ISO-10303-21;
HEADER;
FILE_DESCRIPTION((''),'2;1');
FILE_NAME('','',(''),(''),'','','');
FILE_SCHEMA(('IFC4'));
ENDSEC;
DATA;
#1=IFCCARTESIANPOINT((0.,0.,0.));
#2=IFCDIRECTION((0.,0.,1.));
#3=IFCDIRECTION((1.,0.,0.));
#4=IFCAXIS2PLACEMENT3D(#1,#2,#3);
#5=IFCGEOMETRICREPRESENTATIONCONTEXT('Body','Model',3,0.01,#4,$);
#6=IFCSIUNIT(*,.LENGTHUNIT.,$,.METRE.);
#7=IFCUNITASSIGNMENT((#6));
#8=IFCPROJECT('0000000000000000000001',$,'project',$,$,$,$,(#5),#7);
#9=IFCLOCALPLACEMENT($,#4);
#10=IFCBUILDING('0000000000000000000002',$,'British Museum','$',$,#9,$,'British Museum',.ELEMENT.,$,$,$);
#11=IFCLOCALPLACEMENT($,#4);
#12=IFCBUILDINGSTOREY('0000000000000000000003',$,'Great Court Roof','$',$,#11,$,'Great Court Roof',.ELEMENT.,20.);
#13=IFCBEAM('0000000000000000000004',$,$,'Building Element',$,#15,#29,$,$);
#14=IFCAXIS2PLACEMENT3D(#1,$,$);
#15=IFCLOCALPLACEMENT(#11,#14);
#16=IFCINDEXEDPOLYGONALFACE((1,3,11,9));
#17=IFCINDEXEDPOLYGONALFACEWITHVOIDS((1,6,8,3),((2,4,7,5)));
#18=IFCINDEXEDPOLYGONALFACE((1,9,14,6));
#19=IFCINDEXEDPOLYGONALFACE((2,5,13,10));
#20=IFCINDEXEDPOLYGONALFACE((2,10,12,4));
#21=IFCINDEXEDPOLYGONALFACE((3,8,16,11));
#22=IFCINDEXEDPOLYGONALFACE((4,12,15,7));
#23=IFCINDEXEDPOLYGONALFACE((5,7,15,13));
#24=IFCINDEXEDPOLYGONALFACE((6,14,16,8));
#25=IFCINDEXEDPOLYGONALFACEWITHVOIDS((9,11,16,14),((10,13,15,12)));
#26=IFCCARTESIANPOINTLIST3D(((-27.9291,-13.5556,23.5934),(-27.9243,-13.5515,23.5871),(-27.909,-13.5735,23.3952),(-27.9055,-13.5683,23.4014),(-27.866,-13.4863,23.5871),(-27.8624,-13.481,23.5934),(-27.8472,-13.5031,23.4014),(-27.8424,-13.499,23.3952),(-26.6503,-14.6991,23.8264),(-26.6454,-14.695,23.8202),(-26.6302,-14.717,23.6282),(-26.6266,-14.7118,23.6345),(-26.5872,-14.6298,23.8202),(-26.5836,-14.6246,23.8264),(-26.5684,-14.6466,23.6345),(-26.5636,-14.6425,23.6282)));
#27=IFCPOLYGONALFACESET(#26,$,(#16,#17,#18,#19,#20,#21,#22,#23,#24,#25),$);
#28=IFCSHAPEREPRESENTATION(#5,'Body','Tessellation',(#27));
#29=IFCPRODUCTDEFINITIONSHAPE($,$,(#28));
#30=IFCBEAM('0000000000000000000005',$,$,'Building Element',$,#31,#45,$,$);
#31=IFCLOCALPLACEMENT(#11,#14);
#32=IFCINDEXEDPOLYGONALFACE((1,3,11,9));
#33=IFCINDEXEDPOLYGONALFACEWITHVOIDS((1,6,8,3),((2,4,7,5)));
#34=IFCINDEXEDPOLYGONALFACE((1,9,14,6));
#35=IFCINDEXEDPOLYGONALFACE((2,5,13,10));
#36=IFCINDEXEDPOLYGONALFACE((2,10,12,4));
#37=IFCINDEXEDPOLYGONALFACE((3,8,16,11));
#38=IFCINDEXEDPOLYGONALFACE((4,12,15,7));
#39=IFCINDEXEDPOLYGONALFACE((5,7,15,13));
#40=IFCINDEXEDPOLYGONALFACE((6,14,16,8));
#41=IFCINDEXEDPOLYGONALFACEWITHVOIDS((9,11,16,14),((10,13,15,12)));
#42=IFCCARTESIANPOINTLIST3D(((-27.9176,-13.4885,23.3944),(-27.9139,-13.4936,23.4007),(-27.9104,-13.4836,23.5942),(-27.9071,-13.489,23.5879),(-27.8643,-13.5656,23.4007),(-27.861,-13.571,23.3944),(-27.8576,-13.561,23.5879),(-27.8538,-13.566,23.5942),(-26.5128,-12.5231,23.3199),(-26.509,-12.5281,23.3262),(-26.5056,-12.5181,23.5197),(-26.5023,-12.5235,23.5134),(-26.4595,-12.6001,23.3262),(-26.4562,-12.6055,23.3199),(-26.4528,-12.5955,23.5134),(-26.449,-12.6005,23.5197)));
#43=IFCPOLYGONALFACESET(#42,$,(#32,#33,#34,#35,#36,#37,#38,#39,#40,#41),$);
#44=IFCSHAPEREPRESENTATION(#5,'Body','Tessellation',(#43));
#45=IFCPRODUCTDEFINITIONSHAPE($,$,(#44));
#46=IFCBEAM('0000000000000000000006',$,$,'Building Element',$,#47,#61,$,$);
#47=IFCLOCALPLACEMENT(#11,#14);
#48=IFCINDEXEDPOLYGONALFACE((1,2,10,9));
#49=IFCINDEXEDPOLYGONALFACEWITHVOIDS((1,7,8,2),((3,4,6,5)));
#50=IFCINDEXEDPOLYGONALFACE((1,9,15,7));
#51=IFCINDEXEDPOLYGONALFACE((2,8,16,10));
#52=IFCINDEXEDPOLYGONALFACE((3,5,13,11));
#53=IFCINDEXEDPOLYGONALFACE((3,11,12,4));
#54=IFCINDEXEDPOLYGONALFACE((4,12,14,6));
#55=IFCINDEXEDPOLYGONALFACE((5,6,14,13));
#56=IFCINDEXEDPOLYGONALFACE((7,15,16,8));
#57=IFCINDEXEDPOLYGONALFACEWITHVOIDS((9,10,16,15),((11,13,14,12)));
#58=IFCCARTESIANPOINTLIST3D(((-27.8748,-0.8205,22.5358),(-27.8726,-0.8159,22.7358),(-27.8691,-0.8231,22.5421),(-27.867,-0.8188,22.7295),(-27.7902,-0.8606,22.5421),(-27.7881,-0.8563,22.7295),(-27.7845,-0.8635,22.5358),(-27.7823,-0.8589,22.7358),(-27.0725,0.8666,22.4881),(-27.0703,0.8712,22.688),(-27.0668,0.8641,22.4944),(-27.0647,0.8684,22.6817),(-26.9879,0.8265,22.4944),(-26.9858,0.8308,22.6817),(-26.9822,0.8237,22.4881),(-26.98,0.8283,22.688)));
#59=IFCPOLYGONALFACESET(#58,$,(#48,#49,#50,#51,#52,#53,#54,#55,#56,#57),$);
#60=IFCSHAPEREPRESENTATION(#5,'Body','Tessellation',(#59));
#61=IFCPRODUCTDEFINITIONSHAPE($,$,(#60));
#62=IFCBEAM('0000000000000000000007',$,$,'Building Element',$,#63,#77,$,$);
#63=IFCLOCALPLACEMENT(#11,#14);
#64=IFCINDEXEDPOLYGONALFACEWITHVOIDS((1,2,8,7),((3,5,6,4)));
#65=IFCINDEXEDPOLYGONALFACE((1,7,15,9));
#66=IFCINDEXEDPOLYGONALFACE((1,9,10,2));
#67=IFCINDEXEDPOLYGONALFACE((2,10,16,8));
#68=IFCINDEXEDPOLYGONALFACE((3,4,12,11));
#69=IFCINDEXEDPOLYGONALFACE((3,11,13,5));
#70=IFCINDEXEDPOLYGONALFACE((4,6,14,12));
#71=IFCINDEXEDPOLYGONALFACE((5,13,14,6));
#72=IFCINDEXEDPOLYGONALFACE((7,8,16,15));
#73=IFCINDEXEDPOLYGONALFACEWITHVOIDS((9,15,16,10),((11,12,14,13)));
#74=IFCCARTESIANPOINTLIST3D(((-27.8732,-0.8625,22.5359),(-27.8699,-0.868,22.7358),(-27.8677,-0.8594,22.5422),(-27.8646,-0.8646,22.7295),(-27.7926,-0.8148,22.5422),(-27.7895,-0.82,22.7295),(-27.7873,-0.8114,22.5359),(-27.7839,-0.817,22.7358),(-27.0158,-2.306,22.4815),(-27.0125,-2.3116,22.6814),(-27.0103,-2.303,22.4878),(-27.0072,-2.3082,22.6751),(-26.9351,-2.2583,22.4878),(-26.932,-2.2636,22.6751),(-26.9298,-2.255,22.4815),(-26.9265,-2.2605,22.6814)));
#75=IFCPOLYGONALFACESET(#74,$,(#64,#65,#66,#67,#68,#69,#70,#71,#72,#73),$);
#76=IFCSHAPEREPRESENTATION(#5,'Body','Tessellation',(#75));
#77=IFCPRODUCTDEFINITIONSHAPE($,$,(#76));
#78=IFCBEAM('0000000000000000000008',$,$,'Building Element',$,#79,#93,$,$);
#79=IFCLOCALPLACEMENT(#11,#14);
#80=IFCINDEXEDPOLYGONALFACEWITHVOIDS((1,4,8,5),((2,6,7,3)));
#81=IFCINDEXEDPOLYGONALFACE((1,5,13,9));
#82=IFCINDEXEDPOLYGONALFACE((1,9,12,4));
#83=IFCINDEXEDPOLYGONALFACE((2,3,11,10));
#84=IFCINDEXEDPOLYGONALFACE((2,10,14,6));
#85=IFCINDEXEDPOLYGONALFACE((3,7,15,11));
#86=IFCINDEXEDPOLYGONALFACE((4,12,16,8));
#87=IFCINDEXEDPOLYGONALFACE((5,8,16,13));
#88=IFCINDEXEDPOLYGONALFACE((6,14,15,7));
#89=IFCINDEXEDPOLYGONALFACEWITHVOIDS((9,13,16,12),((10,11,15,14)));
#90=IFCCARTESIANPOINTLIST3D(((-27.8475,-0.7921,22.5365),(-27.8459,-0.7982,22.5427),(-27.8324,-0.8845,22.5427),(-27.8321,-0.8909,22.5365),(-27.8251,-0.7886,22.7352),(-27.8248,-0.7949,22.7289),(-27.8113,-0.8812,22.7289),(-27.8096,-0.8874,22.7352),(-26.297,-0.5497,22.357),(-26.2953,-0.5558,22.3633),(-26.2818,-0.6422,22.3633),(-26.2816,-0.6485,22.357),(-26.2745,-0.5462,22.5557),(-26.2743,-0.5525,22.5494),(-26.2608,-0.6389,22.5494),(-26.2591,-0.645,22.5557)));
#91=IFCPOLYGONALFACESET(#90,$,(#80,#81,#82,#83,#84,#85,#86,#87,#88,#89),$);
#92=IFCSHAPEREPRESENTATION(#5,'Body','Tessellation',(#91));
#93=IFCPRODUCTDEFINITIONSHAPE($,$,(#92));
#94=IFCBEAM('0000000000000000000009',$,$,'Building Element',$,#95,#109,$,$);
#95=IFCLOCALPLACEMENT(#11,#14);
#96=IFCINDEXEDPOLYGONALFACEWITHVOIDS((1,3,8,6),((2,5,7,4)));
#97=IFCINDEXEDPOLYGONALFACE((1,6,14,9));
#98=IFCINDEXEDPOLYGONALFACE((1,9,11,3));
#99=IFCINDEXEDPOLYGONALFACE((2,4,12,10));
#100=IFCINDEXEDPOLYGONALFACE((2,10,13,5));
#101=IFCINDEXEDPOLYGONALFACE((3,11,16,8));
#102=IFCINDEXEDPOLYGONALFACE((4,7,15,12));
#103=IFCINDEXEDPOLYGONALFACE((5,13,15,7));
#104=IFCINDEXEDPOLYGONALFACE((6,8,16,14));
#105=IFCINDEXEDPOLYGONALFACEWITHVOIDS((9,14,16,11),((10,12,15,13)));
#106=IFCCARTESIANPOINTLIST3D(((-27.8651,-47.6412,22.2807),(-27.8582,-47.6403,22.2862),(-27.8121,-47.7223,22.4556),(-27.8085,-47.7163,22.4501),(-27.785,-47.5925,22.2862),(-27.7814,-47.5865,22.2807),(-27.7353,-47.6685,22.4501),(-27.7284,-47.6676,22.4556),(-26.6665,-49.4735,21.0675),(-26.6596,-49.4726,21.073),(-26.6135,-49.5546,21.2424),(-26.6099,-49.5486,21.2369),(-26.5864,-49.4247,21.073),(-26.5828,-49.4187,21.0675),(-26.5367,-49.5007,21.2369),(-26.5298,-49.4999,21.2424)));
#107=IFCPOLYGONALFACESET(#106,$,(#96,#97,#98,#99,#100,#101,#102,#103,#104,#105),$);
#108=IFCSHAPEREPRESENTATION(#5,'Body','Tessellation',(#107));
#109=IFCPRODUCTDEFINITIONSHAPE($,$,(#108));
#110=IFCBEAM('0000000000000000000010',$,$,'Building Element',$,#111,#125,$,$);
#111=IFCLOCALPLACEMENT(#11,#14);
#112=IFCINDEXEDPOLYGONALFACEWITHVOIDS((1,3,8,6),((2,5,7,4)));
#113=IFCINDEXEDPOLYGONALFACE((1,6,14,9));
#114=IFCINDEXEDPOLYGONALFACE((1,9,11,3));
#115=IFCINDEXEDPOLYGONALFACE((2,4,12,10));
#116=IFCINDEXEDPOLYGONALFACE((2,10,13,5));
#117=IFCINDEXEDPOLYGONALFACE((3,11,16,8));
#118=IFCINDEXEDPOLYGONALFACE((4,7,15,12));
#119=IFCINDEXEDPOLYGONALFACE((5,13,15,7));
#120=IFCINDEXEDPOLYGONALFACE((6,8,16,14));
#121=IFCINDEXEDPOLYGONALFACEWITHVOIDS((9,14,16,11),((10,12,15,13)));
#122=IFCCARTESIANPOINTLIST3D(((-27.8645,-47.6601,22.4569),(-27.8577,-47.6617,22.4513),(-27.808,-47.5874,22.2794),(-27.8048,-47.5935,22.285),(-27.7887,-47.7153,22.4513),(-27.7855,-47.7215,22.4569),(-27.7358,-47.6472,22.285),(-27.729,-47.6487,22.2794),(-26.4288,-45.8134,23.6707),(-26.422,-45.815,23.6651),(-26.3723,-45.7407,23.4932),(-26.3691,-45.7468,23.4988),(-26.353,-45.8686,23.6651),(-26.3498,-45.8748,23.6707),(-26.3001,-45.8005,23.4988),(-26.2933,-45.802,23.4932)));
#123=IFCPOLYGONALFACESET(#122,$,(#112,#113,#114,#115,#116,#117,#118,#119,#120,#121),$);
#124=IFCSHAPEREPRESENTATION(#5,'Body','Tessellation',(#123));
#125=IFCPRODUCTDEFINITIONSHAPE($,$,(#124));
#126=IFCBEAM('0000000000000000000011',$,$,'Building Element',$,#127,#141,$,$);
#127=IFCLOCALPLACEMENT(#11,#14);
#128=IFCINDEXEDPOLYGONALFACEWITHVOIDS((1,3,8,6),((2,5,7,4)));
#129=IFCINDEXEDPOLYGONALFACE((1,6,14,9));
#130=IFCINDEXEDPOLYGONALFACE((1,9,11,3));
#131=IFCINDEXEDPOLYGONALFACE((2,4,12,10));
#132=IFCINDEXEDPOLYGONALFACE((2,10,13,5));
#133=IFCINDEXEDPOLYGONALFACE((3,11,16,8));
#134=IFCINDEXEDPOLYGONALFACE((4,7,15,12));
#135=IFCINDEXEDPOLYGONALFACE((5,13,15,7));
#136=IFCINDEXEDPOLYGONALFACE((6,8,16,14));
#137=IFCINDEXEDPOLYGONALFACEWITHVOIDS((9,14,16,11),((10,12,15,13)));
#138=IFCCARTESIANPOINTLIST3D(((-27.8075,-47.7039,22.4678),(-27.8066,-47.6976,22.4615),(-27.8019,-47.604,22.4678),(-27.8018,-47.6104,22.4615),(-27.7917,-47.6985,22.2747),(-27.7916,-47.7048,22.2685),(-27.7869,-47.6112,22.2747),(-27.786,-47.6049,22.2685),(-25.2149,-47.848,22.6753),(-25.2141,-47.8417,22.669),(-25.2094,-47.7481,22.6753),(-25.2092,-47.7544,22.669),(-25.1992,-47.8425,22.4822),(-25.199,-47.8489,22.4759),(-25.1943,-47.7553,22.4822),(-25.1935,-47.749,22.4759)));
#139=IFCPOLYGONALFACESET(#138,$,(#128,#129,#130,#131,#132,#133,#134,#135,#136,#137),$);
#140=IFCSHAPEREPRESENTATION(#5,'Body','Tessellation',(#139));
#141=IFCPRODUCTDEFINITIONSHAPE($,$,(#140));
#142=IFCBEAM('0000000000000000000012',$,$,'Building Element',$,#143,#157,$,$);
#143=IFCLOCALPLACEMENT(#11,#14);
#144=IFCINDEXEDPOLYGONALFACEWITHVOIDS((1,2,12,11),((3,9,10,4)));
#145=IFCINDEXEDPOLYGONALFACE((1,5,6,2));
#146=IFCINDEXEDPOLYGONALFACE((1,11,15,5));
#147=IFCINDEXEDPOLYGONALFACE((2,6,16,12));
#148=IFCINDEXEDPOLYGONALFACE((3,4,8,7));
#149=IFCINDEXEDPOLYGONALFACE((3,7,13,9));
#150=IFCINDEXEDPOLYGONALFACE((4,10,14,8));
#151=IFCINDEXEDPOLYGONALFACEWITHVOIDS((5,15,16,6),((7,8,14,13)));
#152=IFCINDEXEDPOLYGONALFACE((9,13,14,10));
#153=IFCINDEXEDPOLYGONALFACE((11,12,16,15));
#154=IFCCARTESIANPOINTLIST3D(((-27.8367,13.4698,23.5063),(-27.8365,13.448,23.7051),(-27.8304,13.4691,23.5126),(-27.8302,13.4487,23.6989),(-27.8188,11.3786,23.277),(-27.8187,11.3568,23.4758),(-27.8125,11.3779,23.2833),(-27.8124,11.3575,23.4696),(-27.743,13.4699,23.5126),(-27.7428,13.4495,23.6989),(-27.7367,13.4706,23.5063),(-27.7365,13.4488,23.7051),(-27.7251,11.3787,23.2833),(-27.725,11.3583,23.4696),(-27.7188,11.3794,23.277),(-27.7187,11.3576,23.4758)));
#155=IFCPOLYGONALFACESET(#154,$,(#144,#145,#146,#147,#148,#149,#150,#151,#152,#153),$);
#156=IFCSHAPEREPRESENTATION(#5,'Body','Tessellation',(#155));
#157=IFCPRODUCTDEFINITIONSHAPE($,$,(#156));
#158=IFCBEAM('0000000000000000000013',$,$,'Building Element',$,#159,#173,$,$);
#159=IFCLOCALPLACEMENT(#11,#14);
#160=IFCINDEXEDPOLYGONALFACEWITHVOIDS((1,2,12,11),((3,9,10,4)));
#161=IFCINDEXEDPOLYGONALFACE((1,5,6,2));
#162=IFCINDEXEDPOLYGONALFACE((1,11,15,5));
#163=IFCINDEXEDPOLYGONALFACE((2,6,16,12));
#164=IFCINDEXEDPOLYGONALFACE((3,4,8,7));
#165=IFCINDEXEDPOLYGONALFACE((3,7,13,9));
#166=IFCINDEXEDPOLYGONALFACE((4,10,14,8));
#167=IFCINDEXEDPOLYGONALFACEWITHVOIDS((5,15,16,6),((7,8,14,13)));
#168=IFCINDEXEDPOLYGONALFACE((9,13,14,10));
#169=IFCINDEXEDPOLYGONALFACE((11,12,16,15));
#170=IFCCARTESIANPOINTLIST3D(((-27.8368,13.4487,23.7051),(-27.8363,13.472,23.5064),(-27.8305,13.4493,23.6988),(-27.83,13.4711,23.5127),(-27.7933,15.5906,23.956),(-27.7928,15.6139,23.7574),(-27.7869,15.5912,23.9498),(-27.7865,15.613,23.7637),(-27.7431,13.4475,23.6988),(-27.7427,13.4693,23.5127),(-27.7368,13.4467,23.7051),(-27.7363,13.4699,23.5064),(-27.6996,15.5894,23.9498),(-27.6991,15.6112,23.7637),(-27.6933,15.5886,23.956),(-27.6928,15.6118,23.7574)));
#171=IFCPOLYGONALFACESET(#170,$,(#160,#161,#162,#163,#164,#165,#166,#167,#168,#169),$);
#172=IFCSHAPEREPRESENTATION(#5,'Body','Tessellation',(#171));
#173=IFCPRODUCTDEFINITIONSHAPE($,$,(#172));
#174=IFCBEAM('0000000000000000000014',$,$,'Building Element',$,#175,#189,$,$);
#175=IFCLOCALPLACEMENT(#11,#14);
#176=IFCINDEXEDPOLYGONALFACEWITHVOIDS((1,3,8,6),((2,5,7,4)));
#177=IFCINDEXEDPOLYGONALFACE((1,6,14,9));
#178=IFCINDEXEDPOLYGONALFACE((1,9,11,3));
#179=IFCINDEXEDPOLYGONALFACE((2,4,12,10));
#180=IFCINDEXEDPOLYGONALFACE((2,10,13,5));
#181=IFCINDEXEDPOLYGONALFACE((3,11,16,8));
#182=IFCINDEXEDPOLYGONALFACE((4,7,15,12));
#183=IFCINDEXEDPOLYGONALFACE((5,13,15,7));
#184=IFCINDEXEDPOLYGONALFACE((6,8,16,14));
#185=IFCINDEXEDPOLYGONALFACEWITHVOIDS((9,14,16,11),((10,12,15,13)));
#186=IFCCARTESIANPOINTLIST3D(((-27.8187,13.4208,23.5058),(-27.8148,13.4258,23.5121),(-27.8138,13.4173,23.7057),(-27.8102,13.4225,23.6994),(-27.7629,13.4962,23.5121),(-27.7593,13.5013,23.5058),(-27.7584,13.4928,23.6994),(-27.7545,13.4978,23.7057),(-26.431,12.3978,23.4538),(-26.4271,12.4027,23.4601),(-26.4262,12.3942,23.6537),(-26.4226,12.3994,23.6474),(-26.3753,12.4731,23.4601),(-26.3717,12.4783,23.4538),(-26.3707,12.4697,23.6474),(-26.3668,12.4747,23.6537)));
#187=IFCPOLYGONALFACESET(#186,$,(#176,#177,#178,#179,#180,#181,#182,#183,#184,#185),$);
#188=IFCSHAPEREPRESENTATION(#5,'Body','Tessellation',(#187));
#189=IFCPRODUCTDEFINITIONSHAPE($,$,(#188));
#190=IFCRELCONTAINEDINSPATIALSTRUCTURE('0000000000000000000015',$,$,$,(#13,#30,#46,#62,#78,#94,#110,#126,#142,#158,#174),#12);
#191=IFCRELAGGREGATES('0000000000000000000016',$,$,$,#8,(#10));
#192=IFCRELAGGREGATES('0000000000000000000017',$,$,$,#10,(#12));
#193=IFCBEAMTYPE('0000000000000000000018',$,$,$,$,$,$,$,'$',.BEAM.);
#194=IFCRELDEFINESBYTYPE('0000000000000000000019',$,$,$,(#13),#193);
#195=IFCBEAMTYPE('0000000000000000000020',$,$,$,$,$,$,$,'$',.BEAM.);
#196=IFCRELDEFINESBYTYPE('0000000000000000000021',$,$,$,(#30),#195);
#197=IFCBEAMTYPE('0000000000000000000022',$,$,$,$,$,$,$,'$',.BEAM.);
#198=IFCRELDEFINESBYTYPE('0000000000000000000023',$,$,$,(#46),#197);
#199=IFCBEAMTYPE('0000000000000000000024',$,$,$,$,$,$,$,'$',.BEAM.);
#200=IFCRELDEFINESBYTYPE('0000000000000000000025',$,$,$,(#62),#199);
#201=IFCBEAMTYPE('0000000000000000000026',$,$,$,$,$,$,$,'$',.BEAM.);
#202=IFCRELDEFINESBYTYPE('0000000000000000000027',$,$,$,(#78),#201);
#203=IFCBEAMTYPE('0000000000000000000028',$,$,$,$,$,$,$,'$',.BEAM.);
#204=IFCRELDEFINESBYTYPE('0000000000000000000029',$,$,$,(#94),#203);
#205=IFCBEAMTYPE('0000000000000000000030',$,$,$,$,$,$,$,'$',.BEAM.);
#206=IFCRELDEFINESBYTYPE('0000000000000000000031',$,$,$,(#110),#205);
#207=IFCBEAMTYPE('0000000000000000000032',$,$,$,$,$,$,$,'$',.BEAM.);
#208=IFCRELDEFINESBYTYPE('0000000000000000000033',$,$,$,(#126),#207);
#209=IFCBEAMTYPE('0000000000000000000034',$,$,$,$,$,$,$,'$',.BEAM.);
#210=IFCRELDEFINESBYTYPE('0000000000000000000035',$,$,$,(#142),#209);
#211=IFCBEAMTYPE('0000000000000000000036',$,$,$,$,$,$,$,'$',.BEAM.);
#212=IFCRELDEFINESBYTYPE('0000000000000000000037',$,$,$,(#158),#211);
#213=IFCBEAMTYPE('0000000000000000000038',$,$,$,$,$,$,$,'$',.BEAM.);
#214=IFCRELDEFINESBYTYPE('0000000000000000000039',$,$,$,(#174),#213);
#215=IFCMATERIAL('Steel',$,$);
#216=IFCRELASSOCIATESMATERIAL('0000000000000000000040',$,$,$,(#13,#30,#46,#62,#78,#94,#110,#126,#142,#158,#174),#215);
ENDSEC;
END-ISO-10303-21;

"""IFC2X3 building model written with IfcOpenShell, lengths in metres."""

from ifc_helpers import new_model, si_unit, frame, origin_with_axes, origin_2d, place, context, project, spatial, hollow_rectangle, extrude, material, type_object, element, save


model = new_model("IFC2X3")

# Units and contexts
model_context = context("Model", 3, precision=0.01, world=origin_with_axes(), identifier="Body")
ifc_project = project(units=[si_unit("LENGTHUNIT", "METRE")], contexts=[model_context])

# Building, storey
building_placement = place(None, origin_with_axes())
building = spatial("IfcBuilding", under=ifc_project, at=building_placement, Name="British Museum", Description="$", LongName="British Museum", CompositionType="ELEMENT")
storey_placement = place(None, origin_with_axes())
storey = spatial("IfcBuildingStorey", under=building, at=storey_placement, Name="Great Court Roof", Description="$", LongName="Great Court Roof", CompositionType="ELEMENT", Elevation=20.0)

# Beams
ifc_material = material(Name="Steel")
beam_type_1 = type_object("IfcBeamType", ElementType="$", PredefinedType="BEAM")
beam_1_placement = place(None, origin_with_axes())
element("IfcBeam", 1, at=beam_1_placement, inside=storey, type_object=beam_type_1, material=ifc_material, Description="Building Element", context=model_context, shape_type="SweptSolid", body=[
    extrude(hollow_rectangle(XDim=0.1, YDim=0.2, WallThickness=0.0063, InnerFilletRadius=0.0, OuterFilletRadius=0.0, at=origin_2d()), frame((-27.8857, -13.5273, 23.4943), z_axis=(0.738655, -0.660507, 0.134605), x_axis=(0.666573, 0.74544, 0.0)), (0.0, 0.0, 1.0), 1.7313),
])
beam_type_2 = type_object("IfcBeamType", ElementType="$", PredefinedType="BEAM")
beam_2_placement = place(None, origin_with_axes())
element("IfcBeam", 2, at=beam_2_placement, inside=storey, type_object=beam_type_2, material=ifc_material, Description="Building Element", context=model_context, shape_type="SweptSolid", body=[
    extrude(hollow_rectangle(XDim=0.1, YDim=0.2, WallThickness=0.0063, InnerFilletRadius=0.0, OuterFilletRadius=0.0, at=origin_2d()), frame((-27.8857, -13.5273, 23.4943), z_axis=(0.823355, 0.565844, -0.043662), x_axis=(-0.566384, 0.824141, 0.0)), (0.0, 0.0, 1.0), 1.7062),
])
beam_type_3 = type_object("IfcBeamType", ElementType="$", PredefinedType="BEAM")
beam_3_placement = place(None, origin_with_axes())
element("IfcBeam", 3, at=beam_3_placement, inside=storey, type_object=beam_type_3, material=ifc_material, Description="Building Element", context=model_context, shape_type="SweptSolid", body=[
    extrude(hollow_rectangle(XDim=0.1, YDim=0.2, WallThickness=0.0063, InnerFilletRadius=0.0, OuterFilletRadius=0.0, at=origin_2d()), frame((-27.8286, -0.8397, 22.6358), z_axis=(0.429308, 0.902796, -0.025568), x_axis=(-0.903091, 0.429449, 0.0)), (0.0, 0.0, 1.0), 1.8688),
])
beam_type_4 = type_object("IfcBeamType", ElementType="$", PredefinedType="BEAM")
beam_4_placement = place(None, origin_with_axes())
element("IfcBeam", 4, at=beam_4_placement, inside=storey, type_object=beam_type_4, material=ifc_material, Description="Building Element", context=model_context, shape_type="SweptSolid", body=[
    extrude(hollow_rectangle(XDim=0.1, YDim=0.2, WallThickness=0.0063, InnerFilletRadius=0.0, OuterFilletRadius=0.0, at=origin_2d()), frame((-27.8286, -0.8397, 22.6358), z_axis=(0.510407, -0.859324, -0.032365), x_axis=(0.859774, 0.510674, 0.0)), (0.0, 0.0, 1.0), 1.6799),
])
beam_type_5 = type_object("IfcBeamType", ElementType="$", PredefinedType="BEAM")
beam_5_placement = place(None, origin_with_axes())
element("IfcBeam", 5, at=beam_5_placement, inside=storey, type_object=beam_type_5, material=ifc_material, Description="Building Element", context=model_context, shape_type="SweptSolid", body=[
    extrude(hollow_rectangle(XDim=0.1, YDim=0.2, WallThickness=0.0063, InnerFilletRadius=0.0, OuterFilletRadius=0.0, at=origin_2d()), frame((-27.8286, -0.8397, 22.6358), z_axis=(0.981605, 0.153433, -0.113618), x_axis=(-0.154433, 0.988003, 0.0)), (0.0, 0.0, 1.0), 1.5796),
])
beam_type_6 = type_object("IfcBeamType", ElementType="$", PredefinedType="BEAM")
beam_6_placement = place(None, origin_with_axes())
element("IfcBeam", 6, at=beam_6_placement, inside=storey, type_object=beam_type_6, material=ifc_material, Description="Building Element", context=model_context, shape_type="SweptSolid", body=[
    extrude(hollow_rectangle(XDim=0.1, YDim=0.2, WallThickness=0.0063, InnerFilletRadius=0.0, OuterFilletRadius=0.0, at=origin_2d()), frame((-27.7968, -47.6544, 22.3681), z_axis=(0.478843, -0.731992, -0.484662), x_axis=(0.836847, 0.547436, 0.0)), (0.0, 0.0, 1.0), 2.5031),
])
beam_type_7 = type_object("IfcBeamType", ElementType="$", PredefinedType="BEAM")
beam_7_placement = place(None, origin_with_axes())
element("IfcBeam", 7, at=beam_7_placement, inside=storey, type_object=beam_type_7, material=ifc_material, Description="Building Element", context=model_context, shape_type="SweptSolid", body=[
    extrude(hollow_rectangle(XDim=0.1, YDim=0.2, WallThickness=0.0063, InnerFilletRadius=0.0, OuterFilletRadius=0.0, at=origin_2d()), frame((-27.7968, -47.6544, 22.3681), z_axis=(0.544798, 0.700752, 0.460589), x_axis=(-0.789478, 0.613779, 0.0)), (0.0, 0.0, 1.0), 2.6353),
])
beam_type_8 = type_object("IfcBeamType", ElementType="$", PredefinedType="BEAM")
beam_8_placement = place(None, origin_with_axes())
element("IfcBeam", 8, at=beam_8_placement, inside=storey, type_object=beam_type_8, material=ifc_material, Description="Building Element", context=model_context, shape_type="SweptSolid", body=[
    extrude(hollow_rectangle(XDim=0.1, YDim=0.2, WallThickness=0.0063, InnerFilletRadius=0.0, OuterFilletRadius=0.0, at=origin_2d()), frame((-27.7968, -47.6544, 22.3681), z_axis=(0.995288, -0.055316, 0.07964), x_axis=(0.055492, 0.998459, 0.0)), (0.0, 0.0, 1.0), 2.6048),
])
beam_type_9 = type_object("IfcBeamType", ElementType="$", PredefinedType="BEAM")
beam_9_placement = place(None, origin_with_axes())
element("IfcBeam", 9, at=beam_9_placement, inside=storey, type_object=beam_type_9, material=ifc_material, Description="Building Element", context=model_context, shape_type="SweptSolid", body=[
    extrude(hollow_rectangle(XDim=0.1, YDim=0.2, WallThickness=0.0063, InnerFilletRadius=0.0, OuterFilletRadius=0.0, at=origin_2d()), frame((-27.7866, 13.4593, 23.6057), z_axis=(0.00847, -0.994007, -0.108991), x_axis=(0.999964, 0.008521, 0.0)), (0.0, 0.0, 1.0), 2.1038),
])
beam_type_10 = type_object("IfcBeamType", ElementType="$", PredefinedType="BEAM")
beam_10_placement = place(None, origin_with_axes())
element("IfcBeam", 10, at=beam_10_placement, inside=storey, type_object=beam_type_10, material=ifc_material, Description="Building Element", context=model_context, shape_type="SweptSolid", body=[
    extrude(hollow_rectangle(XDim=0.1, YDim=0.2, WallThickness=0.0063, InnerFilletRadius=0.0, OuterFilletRadius=0.0, at=origin_2d()), frame((-27.7866, 13.4593, 23.6057), z_axis=(0.020187, 0.993001, 0.116365), x_axis=(-0.999793, 0.020325, 0.0)), (0.0, 0.0, 1.0), 2.157),
])
beam_type_11 = type_object("IfcBeamType", ElementType="$", PredefinedType="BEAM")
beam_11_placement = place(None, origin_with_axes())
element("IfcBeam", 11, at=beam_11_placement, inside=storey, type_object=beam_type_11, material=ifc_material, Description="Building Element", context=model_context, shape_type="SweptSolid", body=[
    extrude(hollow_rectangle(XDim=0.1, YDim=0.2, WallThickness=0.0063, InnerFilletRadius=0.0, OuterFilletRadius=0.0, at=origin_2d()), frame((-27.7866, 13.4593, 23.6057), z_axis=(0.804525, -0.593153, -0.03015), x_axis=(0.593423, 0.804891, 0.0)), (0.0, 0.0, 1.0), 1.7248),
])

save(model, "model.ifc")
